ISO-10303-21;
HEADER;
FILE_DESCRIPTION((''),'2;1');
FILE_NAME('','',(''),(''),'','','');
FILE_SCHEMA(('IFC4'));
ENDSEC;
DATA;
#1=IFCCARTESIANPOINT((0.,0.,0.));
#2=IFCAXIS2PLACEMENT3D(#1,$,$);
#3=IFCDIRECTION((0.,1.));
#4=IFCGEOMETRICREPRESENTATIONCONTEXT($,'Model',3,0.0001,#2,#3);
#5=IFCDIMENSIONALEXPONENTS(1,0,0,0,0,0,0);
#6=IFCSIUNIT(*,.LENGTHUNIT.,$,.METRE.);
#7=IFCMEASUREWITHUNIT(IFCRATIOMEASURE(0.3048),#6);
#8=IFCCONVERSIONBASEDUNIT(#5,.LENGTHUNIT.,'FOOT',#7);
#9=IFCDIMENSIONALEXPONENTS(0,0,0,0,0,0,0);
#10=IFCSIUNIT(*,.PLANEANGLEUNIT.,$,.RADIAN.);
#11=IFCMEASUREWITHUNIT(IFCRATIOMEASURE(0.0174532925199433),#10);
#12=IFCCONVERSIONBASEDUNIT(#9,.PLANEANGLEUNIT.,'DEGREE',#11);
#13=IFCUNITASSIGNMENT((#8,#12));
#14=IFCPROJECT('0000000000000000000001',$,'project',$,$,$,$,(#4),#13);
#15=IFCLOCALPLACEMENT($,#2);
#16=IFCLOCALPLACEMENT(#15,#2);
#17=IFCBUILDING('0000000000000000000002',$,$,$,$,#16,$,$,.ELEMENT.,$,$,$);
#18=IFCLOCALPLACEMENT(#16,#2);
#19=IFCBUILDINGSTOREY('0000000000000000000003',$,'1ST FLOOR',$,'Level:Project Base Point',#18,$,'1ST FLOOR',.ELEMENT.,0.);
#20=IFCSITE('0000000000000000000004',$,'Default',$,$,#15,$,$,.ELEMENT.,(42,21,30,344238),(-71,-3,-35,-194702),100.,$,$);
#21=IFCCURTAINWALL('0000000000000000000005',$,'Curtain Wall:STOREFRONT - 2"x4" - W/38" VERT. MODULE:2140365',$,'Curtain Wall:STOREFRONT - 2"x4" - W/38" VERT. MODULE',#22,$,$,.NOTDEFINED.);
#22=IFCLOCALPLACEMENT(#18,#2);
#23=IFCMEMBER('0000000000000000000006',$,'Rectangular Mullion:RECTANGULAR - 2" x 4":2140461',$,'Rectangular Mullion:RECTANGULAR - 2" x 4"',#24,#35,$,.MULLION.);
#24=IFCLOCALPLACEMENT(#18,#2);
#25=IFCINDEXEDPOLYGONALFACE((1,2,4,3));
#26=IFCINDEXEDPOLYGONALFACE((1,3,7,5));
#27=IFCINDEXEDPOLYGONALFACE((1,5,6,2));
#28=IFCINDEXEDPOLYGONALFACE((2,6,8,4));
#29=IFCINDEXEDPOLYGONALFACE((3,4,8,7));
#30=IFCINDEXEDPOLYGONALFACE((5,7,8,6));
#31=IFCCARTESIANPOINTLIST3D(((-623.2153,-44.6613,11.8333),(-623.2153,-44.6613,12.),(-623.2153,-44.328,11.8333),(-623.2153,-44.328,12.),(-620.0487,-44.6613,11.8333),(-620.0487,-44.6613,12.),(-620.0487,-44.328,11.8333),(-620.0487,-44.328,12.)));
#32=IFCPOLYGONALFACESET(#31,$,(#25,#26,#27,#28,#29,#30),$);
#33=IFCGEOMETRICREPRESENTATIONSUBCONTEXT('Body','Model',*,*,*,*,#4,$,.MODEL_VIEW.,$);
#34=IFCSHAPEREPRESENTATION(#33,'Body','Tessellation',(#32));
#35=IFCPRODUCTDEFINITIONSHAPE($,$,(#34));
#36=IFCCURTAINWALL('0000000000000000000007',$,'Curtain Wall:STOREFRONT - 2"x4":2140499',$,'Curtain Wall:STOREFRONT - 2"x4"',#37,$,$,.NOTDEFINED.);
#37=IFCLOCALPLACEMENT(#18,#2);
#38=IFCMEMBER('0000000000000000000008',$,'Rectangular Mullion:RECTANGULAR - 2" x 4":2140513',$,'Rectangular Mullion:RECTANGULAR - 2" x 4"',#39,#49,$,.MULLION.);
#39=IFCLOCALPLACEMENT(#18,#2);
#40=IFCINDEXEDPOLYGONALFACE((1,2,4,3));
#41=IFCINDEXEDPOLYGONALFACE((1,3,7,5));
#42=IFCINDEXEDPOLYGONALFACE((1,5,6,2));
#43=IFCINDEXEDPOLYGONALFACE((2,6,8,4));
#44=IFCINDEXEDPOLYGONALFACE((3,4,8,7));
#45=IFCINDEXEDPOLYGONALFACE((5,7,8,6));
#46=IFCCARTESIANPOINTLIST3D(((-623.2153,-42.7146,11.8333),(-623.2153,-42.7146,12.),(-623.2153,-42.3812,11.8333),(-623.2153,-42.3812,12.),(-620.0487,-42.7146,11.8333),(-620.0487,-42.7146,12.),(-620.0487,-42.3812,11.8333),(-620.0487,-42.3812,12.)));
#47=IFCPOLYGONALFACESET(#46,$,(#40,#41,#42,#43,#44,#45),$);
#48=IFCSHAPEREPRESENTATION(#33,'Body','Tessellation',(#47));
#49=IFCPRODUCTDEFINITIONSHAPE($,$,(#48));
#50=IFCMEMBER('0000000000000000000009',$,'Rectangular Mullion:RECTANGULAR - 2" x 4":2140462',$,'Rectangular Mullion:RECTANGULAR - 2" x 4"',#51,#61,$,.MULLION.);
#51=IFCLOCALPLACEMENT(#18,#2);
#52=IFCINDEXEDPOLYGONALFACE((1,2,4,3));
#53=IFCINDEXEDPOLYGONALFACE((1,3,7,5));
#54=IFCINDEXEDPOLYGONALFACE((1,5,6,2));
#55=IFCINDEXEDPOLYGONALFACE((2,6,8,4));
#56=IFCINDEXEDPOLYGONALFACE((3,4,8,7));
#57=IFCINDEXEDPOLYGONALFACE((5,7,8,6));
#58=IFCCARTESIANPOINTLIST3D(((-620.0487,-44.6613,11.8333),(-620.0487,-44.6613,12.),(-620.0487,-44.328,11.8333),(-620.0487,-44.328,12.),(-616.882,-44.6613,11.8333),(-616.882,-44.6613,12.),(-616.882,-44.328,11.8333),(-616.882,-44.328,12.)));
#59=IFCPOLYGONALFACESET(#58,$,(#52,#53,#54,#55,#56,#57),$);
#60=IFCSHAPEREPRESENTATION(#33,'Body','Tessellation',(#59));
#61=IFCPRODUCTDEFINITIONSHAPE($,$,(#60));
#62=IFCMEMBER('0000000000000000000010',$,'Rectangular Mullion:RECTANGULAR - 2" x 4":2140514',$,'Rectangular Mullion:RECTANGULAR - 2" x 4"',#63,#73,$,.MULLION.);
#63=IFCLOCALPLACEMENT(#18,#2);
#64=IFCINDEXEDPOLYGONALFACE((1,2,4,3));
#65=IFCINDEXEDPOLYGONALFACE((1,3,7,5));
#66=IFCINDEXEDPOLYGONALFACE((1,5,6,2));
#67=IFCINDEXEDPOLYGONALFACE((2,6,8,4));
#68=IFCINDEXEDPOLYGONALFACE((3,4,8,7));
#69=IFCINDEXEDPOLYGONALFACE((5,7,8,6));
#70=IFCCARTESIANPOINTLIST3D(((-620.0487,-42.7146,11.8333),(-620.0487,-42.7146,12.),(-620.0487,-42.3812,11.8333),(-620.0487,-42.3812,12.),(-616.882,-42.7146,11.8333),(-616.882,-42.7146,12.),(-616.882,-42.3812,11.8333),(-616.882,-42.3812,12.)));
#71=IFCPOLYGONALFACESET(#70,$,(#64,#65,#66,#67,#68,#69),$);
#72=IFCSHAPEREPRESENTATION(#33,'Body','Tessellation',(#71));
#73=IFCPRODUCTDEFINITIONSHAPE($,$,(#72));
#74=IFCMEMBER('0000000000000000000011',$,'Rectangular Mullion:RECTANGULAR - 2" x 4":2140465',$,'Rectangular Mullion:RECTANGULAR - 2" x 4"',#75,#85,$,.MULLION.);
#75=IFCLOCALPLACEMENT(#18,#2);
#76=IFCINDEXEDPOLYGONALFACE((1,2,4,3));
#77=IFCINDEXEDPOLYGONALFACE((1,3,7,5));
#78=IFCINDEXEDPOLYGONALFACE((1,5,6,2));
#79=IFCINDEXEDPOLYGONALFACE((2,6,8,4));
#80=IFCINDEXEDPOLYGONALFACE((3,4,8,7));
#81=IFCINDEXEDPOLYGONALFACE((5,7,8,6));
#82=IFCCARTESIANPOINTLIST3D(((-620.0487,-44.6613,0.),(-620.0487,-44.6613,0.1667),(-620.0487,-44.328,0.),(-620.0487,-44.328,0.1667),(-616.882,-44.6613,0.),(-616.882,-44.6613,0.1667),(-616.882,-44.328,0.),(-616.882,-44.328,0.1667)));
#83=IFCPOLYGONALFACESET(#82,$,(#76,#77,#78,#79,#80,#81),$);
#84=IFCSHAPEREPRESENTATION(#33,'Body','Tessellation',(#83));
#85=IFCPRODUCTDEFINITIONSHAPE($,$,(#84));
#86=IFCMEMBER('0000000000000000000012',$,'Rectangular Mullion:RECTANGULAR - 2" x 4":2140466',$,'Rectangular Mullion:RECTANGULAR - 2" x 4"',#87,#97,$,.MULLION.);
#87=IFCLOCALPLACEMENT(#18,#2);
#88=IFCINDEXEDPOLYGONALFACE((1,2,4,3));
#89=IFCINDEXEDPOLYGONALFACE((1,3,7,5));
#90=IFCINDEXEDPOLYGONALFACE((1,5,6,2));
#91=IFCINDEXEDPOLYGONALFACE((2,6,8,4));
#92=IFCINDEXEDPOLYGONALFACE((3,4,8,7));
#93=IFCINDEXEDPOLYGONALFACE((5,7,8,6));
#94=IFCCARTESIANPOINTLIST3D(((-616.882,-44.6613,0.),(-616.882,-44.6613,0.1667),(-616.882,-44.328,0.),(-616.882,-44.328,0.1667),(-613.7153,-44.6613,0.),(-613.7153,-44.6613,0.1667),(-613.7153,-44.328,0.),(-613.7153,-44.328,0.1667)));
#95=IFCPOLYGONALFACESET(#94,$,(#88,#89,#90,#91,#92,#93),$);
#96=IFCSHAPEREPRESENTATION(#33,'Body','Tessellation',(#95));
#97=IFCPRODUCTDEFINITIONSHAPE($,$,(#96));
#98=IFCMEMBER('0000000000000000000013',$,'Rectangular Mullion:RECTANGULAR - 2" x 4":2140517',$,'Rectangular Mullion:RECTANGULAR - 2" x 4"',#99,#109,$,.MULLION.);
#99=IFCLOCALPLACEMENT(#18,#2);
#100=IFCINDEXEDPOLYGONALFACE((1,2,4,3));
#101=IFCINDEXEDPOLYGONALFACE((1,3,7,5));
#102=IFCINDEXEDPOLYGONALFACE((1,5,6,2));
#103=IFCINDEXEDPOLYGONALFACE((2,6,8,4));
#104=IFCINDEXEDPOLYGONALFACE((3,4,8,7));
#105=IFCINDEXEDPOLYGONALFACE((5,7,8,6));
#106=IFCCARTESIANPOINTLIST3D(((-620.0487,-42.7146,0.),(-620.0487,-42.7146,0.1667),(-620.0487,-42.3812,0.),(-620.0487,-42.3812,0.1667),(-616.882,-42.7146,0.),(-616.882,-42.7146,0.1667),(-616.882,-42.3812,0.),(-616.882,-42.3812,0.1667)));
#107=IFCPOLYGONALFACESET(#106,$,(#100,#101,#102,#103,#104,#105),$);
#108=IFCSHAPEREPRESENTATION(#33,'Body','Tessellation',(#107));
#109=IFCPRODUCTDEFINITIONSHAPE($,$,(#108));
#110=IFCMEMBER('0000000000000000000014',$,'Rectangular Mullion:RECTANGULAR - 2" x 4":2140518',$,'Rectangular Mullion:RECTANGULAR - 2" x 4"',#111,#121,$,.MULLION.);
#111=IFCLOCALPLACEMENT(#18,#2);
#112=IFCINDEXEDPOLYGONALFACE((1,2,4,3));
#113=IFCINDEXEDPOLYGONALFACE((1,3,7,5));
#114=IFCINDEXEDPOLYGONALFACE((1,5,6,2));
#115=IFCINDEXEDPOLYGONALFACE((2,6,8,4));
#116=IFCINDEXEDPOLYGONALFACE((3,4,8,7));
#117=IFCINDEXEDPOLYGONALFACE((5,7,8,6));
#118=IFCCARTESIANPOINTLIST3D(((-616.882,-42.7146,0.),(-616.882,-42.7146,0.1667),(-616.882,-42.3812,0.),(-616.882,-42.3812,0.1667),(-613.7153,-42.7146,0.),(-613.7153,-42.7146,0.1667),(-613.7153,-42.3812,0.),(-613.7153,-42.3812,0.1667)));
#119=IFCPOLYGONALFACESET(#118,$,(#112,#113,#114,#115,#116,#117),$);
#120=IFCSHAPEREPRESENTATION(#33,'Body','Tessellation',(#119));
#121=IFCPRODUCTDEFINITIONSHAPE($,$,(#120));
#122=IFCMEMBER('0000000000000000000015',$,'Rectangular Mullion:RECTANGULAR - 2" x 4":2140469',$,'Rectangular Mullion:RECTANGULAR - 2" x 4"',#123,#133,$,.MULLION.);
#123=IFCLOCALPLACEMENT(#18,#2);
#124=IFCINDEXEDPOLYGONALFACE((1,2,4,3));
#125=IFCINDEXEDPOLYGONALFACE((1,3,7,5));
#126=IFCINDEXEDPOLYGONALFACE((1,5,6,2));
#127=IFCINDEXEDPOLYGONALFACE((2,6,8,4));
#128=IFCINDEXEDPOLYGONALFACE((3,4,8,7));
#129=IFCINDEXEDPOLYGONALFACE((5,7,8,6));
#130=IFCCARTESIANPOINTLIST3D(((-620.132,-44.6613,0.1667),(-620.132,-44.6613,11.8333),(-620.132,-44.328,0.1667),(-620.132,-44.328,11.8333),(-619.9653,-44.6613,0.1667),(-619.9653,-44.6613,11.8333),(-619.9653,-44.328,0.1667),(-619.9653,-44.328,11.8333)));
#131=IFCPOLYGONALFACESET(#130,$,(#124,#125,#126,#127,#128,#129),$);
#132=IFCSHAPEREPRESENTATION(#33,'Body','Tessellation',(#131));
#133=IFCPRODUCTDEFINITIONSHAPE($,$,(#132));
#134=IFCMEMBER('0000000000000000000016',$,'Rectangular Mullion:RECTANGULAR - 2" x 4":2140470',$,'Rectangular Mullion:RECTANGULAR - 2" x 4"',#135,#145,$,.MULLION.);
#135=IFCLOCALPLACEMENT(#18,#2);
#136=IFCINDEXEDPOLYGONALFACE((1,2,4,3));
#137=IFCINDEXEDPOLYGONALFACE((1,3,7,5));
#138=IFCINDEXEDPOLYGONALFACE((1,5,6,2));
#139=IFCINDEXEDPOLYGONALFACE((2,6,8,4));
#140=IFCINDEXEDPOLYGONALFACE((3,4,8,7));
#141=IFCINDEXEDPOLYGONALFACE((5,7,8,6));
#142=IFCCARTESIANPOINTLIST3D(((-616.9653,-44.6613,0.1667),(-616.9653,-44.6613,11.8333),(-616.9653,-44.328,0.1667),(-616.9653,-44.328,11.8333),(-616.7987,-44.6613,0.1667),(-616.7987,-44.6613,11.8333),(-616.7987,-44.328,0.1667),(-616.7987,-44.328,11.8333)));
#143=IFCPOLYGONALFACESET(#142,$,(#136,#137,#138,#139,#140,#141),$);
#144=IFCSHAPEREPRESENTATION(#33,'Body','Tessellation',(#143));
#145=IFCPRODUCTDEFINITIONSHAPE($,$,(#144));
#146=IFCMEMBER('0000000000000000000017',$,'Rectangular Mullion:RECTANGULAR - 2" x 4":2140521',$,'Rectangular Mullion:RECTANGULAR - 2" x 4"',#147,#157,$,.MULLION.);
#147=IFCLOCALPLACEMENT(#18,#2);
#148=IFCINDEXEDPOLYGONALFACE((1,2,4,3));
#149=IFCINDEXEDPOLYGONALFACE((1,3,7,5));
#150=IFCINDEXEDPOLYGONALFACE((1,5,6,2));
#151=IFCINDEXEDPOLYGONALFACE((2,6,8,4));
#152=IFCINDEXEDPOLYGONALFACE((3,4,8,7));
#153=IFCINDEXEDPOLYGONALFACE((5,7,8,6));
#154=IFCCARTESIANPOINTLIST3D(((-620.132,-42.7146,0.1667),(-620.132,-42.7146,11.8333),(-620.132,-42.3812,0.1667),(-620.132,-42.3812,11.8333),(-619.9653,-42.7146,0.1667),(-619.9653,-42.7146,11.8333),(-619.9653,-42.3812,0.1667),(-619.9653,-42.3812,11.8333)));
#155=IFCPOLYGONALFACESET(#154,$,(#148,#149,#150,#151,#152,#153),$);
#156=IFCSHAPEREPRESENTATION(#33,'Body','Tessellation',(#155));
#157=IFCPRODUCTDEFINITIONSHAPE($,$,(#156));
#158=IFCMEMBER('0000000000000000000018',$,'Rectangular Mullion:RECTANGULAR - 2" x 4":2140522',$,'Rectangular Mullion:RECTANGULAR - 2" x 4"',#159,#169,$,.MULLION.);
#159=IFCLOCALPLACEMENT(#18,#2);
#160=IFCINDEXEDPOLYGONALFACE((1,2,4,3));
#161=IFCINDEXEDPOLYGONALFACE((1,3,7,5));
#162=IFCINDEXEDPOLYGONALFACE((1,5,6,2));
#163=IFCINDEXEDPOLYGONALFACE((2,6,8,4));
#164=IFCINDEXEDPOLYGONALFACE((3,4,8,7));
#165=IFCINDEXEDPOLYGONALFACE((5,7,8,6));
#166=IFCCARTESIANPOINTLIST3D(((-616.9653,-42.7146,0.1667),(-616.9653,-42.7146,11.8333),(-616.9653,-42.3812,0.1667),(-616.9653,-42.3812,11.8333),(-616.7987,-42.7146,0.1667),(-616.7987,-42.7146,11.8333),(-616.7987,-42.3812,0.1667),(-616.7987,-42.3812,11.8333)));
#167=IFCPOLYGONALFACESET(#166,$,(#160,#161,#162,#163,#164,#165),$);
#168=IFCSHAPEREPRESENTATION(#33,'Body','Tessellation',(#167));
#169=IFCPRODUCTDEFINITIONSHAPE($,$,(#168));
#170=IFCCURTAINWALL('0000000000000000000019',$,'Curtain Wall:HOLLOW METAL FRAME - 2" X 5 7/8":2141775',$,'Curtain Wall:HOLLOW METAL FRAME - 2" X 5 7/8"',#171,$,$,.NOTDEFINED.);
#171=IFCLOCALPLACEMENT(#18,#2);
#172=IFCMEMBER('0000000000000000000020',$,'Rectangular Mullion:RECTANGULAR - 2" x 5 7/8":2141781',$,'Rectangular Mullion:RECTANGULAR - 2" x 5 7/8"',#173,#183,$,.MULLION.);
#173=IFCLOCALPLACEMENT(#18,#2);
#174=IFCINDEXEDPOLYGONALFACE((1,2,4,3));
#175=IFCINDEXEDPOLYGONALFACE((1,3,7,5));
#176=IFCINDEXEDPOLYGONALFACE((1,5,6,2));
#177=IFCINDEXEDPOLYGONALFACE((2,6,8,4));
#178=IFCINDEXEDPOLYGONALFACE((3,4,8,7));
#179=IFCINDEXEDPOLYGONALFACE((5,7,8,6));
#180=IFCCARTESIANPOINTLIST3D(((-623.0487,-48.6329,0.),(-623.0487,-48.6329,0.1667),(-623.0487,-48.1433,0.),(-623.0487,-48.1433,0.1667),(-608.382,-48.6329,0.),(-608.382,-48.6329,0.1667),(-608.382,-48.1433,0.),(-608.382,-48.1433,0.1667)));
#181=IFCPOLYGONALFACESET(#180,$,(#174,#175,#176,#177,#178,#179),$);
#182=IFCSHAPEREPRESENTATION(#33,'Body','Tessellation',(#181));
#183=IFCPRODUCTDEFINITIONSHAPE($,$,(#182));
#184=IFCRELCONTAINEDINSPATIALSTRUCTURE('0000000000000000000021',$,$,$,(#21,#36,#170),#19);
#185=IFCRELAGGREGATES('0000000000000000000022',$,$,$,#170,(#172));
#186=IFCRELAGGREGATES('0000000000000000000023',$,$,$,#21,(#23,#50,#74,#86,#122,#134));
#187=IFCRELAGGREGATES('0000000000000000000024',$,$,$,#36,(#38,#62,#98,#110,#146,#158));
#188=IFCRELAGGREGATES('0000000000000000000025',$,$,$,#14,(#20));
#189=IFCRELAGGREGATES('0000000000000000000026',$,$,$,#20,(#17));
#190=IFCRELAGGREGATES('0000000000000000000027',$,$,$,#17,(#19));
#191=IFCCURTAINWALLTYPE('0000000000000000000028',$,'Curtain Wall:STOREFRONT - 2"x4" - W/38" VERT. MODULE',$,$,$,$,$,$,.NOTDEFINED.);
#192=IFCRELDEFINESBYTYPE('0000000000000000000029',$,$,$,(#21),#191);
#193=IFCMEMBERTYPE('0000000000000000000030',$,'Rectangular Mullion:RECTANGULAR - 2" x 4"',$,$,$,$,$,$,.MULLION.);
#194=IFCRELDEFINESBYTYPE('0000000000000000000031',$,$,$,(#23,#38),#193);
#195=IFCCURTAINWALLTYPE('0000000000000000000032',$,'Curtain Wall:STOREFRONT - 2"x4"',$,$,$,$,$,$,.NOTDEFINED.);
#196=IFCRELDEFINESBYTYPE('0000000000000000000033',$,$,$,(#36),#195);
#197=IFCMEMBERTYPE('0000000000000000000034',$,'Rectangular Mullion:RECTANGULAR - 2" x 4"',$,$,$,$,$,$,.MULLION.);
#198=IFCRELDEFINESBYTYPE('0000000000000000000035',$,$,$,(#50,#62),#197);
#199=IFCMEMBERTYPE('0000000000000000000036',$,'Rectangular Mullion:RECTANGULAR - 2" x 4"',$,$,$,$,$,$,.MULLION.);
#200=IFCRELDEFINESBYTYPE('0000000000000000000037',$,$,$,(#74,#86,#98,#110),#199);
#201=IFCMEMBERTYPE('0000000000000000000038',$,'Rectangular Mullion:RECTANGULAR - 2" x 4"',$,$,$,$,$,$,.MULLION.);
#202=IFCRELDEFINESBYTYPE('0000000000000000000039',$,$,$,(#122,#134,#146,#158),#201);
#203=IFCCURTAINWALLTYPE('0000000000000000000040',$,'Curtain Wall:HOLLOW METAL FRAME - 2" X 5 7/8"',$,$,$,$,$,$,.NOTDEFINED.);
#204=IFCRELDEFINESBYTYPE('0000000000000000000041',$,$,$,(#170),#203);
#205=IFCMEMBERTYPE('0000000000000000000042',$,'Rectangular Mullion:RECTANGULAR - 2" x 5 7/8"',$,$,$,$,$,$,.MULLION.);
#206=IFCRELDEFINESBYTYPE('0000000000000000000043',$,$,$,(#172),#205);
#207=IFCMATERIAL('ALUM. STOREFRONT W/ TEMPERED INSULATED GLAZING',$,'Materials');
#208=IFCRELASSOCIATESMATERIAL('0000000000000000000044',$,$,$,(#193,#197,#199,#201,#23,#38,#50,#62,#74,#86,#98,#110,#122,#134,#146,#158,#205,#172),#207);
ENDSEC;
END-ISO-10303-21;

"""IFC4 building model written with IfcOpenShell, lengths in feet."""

from ifc_helpers import new_model, entity, si_unit, converted_unit, direction, frame, origin, origin_2d_with_axis, place, context, subcontext, project, spatial, rectangle, extrude, source, transform, mapped, material, material_profile, profile_set, profile_usage, type_object, type_shapes, element, aggregate, save


model = new_model("IFC4")

# Units and contexts
model_context = context("Model", 3, precision=0.0001, world=origin(), true_north=direction((0.0, 1.0)))
body_context = subcontext(model_context, "Body", "Model", "MODEL_VIEW")
ifc_project = project(units=[converted_unit("LENGTHUNIT", "FOOT", entity("IfcRatioMeasure", 0.3048), si_unit("LENGTHUNIT", "METRE"), dimensions=[1, 0, 0, 0, 0, 0, 0]), converted_unit("PLANEANGLEUNIT", "DEGREE", entity("IfcRatioMeasure", 0.0174532925199433), si_unit("PLANEANGLEUNIT", "RADIAN"), dimensions=[0, 0, 0, 0, 0, 0, 0])], contexts=[model_context])

# Site, building, storey
site_placement = place(None, origin())
site = spatial("IfcSite", under=ifc_project, at=site_placement, Name="Default", CompositionType="ELEMENT", RefLatitude=(42, 21, 30, 344238), RefLongitude=(-71, -3, -35, -194702), RefElevation=100.0)
building_placement = place(site_placement, origin())
building = spatial("IfcBuilding", under=site, at=building_placement, CompositionType="ELEMENT")
storey_placement = place(building_placement, origin())
storey = spatial("IfcBuildingStorey", under=building, at=storey_placement, Name="1ST FLOOR", ObjectType="Level:Project Base Point", LongName="1ST FLOOR", CompositionType="ELEMENT", Elevation=0.0)

# Curtain walls, members
curtain_wall_type_1 = type_object("IfcCurtainWallType", Name="Curtain Wall:STOREFRONT - 2\"x4\" - W/38\" VERT. MODULE", PredefinedType="NOTDEFINED")
curtain_wall_1_placement = place(storey_placement, origin())
curtain_wall_1 = element("IfcCurtainWall", 1, at=curtain_wall_1_placement, inside=storey, type_object=curtain_wall_type_1, Name="Curtain Wall:STOREFRONT - 2\"x4\" - W/38\" VERT. MODULE:2140365", ObjectType="Curtain Wall:STOREFRONT - 2\"x4\" - W/38\" VERT. MODULE", PredefinedType="NOTDEFINED")
ifc_material_1 = material(Name="ALUM. STOREFRONT W/ TEMPERED INSULATED GLAZING", Category="Materials")
ifc_material_profile_1 = material_profile(ifc_material_1, rectangle(XDim=0.3333, YDim=0.1667, at=origin_2d_with_axis()), Name="RECTANGULAR - 2\" x 4\"")
ifc_profile_set_1 = profile_set([ifc_material_profile_1], Name="RECTANGULAR - 2\" x 4\"")
ifc_profile_usage_1 = profile_usage(ifc_profile_set_1)
member_type_1 = type_object("IfcMemberType", Name="Rectangular Mullion:RECTANGULAR - 2\" x 4\"", PredefinedType="MULLION", material=ifc_profile_set_1)
shared_shape_1 = source(origin(), body_context, "Body", "SweptSolid", [
    extrude(rectangle(XDim=0.3333, YDim=0.1667, at=origin_2d_with_axis()), frame((-0.0833, 0.0, -3.1667), z_axis=(0.0, 0.0, 1.0), x_axis=(0.0, -1.0, 0.0)), (0.0, 0.0, 1.0), 3.1667),
])
type_shapes(member_type_1, [shared_shape_1])
member_1_placement = place(storey_placement, frame((-620.0487, -44.4946, 12.0), z_axis=(1.0, 0.0, 0.0), x_axis=(0.0, 0.0, 1.0)))
member_1 = element("IfcMember", 2, at=member_1_placement, type_object=member_type_1, material=ifc_profile_usage_1, Name="Rectangular Mullion:RECTANGULAR - 2\" x 4\":2140461", ObjectType="Rectangular Mullion:RECTANGULAR - 2\" x 4\"", PredefinedType="MULLION", context=body_context, shape_type="MappedRepresentation", body=[
    mapped(shared_shape_1, transform((0.0, 0.0, 0.0), scale=1.0)),
])
curtain_wall_type_2 = type_object("IfcCurtainWallType", Name="Curtain Wall:STOREFRONT - 2\"x4\"", PredefinedType="NOTDEFINED")
curtain_wall_2_placement = place(storey_placement, origin())
curtain_wall_2 = element("IfcCurtainWall", 3, at=curtain_wall_2_placement, inside=storey, type_object=curtain_wall_type_2, Name="Curtain Wall:STOREFRONT - 2\"x4\":2140499", ObjectType="Curtain Wall:STOREFRONT - 2\"x4\"", PredefinedType="NOTDEFINED")
ifc_profile_usage_2 = profile_usage(ifc_profile_set_1)
member_2_placement = place(storey_placement, frame((-620.0487, -42.5479, 12.0), z_axis=(1.0, 0.0, 0.0), x_axis=(0.0, 0.0, 1.0)))
member_2 = element("IfcMember", 4, at=member_2_placement, type_object=member_type_1, material=ifc_profile_usage_2, Name="Rectangular Mullion:RECTANGULAR - 2\" x 4\":2140513", ObjectType="Rectangular Mullion:RECTANGULAR - 2\" x 4\"", PredefinedType="MULLION", context=body_context, shape_type="MappedRepresentation", body=[
    mapped(shared_shape_1, transform((0.0, 0.0, 0.0), scale=1.0)),
])

# Members
ifc_profile_usage_3 = profile_usage(ifc_profile_set_1)
member_type_2 = type_object("IfcMemberType", Name="Rectangular Mullion:RECTANGULAR - 2\" x 4\"", PredefinedType="MULLION", material=ifc_profile_set_1)
shared_shape_2 = source(origin(), body_context, "Body", "SweptSolid", [
    extrude(rectangle(XDim=0.3333, YDim=0.1667, at=origin_2d_with_axis()), frame((-0.0833, 0.0, -3.1667), z_axis=(0.0, 0.0, 1.0), x_axis=(0.0, -1.0, 0.0)), (0.0, 0.0, 1.0), 3.1667),
])
type_shapes(member_type_2, [shared_shape_2])
member_3_placement = place(storey_placement, frame((-616.882, -44.4946, 12.0), z_axis=(1.0, 0.0, 0.0), x_axis=(0.0, 0.0, 1.0)))
member_3 = element("IfcMember", 5, at=member_3_placement, type_object=member_type_2, material=ifc_profile_usage_3, Name="Rectangular Mullion:RECTANGULAR - 2\" x 4\":2140462", ObjectType="Rectangular Mullion:RECTANGULAR - 2\" x 4\"", PredefinedType="MULLION", context=body_context, shape_type="MappedRepresentation", body=[
    mapped(shared_shape_2, transform((0.0, 0.0, 0.0), scale=1.0)),
])
ifc_profile_usage_4 = profile_usage(ifc_profile_set_1)
member_4_placement = place(storey_placement, frame((-616.882, -42.5479, 12.0), z_axis=(1.0, 0.0, 0.0), x_axis=(0.0, 0.0, 1.0)))
member_4 = element("IfcMember", 6, at=member_4_placement, type_object=member_type_2, material=ifc_profile_usage_4, Name="Rectangular Mullion:RECTANGULAR - 2\" x 4\":2140514", ObjectType="Rectangular Mullion:RECTANGULAR - 2\" x 4\"", PredefinedType="MULLION", context=body_context, shape_type="MappedRepresentation", body=[
    mapped(shared_shape_2, transform((0.0, 0.0, 0.0), scale=1.0)),
])
ifc_profile_usage_5 = profile_usage(ifc_profile_set_1)
member_type_3 = type_object("IfcMemberType", Name="Rectangular Mullion:RECTANGULAR - 2\" x 4\"", PredefinedType="MULLION", material=ifc_profile_set_1)
shared_shape_3 = source(origin(), body_context, "Body", "SweptSolid", [
    extrude(rectangle(XDim=0.3333, YDim=0.1667, at=origin_2d_with_axis()), frame((-0.0833, 0.0, -3.1667), z_axis=(0.0, 0.0, 1.0), x_axis=(0.0, -1.0, 0.0)), (0.0, 0.0, 1.0), 3.1667),
])
type_shapes(member_type_3, [shared_shape_3])
member_5_placement = place(storey_placement, frame((-620.0487, -44.4946, 0.0), z_axis=(-1.0, 0.0, 0.0), x_axis=(0.0, 0.0, -1.0)))
member_5 = element("IfcMember", 7, at=member_5_placement, type_object=member_type_3, material=ifc_profile_usage_5, Name="Rectangular Mullion:RECTANGULAR - 2\" x 4\":2140465", ObjectType="Rectangular Mullion:RECTANGULAR - 2\" x 4\"", PredefinedType="MULLION", context=body_context, shape_type="MappedRepresentation", body=[
    mapped(shared_shape_3, transform((0.0, 0.0, 0.0), scale=1.0)),
])
ifc_profile_usage_6 = profile_usage(ifc_profile_set_1)
member_6_placement = place(storey_placement, frame((-616.882, -44.4946, 0.0), z_axis=(-1.0, 0.0, 0.0), x_axis=(0.0, 0.0, -1.0)))
member_6 = element("IfcMember", 8, at=member_6_placement, type_object=member_type_3, material=ifc_profile_usage_6, Name="Rectangular Mullion:RECTANGULAR - 2\" x 4\":2140466", ObjectType="Rectangular Mullion:RECTANGULAR - 2\" x 4\"", PredefinedType="MULLION", context=body_context, shape_type="MappedRepresentation", body=[
    mapped(shared_shape_3, transform((0.0, 0.0, 0.0), scale=1.0)),
])
ifc_profile_usage_7 = profile_usage(ifc_profile_set_1)
member_7_placement = place(storey_placement, frame((-620.0487, -42.5479, 0.0), z_axis=(-1.0, 0.0, 0.0), x_axis=(0.0, 0.0, -1.0)))
member_7 = element("IfcMember", 9, at=member_7_placement, type_object=member_type_3, material=ifc_profile_usage_7, Name="Rectangular Mullion:RECTANGULAR - 2\" x 4\":2140517", ObjectType="Rectangular Mullion:RECTANGULAR - 2\" x 4\"", PredefinedType="MULLION", context=body_context, shape_type="MappedRepresentation", body=[
    mapped(shared_shape_3, transform((0.0, 0.0, 0.0), scale=1.0)),
])
ifc_profile_usage_8 = profile_usage(ifc_profile_set_1)
member_8_placement = place(storey_placement, frame((-616.882, -42.5479, 0.0), z_axis=(-1.0, 0.0, 0.0), x_axis=(0.0, 0.0, -1.0)))
member_8 = element("IfcMember", 10, at=member_8_placement, type_object=member_type_3, material=ifc_profile_usage_8, Name="Rectangular Mullion:RECTANGULAR - 2\" x 4\":2140518", ObjectType="Rectangular Mullion:RECTANGULAR - 2\" x 4\"", PredefinedType="MULLION", context=body_context, shape_type="MappedRepresentation", body=[
    mapped(shared_shape_3, transform((0.0, 0.0, 0.0), scale=1.0)),
])
ifc_profile_usage_9 = profile_usage(ifc_profile_set_1)
member_type_4 = type_object("IfcMemberType", Name="Rectangular Mullion:RECTANGULAR - 2\" x 4\"", PredefinedType="MULLION", material=ifc_profile_set_1)
shared_shape_4 = source(origin(), body_context, "Body", "SweptSolid", [
    extrude(rectangle(XDim=0.3333, YDim=0.1667, at=origin_2d_with_axis()), frame((0.0, 0.0, -11.6667), z_axis=(0.0, 0.0, 1.0), x_axis=(0.0, -1.0, 0.0)), (0.0, 0.0, 1.0), 11.6667),
])
type_shapes(member_type_4, [shared_shape_4])
member_9_placement = place(storey_placement, frame((-620.0487, -44.4946, 0.1667), z_axis=(0.0, 0.0, -1.0), x_axis=(1.0, 0.0, 0.0)))
member_9 = element("IfcMember", 11, at=member_9_placement, type_object=member_type_4, material=ifc_profile_usage_9, Name="Rectangular Mullion:RECTANGULAR - 2\" x 4\":2140469", ObjectType="Rectangular Mullion:RECTANGULAR - 2\" x 4\"", PredefinedType="MULLION", context=body_context, shape_type="MappedRepresentation", body=[
    mapped(shared_shape_4, transform((0.0, 0.0, 0.0), scale=1.0)),
])
ifc_profile_usage_10 = profile_usage(ifc_profile_set_1)
member_10_placement = place(storey_placement, frame((-616.882, -44.4946, 0.1667), z_axis=(0.0, 0.0, -1.0), x_axis=(1.0, 0.0, 0.0)))
member_10 = element("IfcMember", 12, at=member_10_placement, type_object=member_type_4, material=ifc_profile_usage_10, Name="Rectangular Mullion:RECTANGULAR - 2\" x 4\":2140470", ObjectType="Rectangular Mullion:RECTANGULAR - 2\" x 4\"", PredefinedType="MULLION", context=body_context, shape_type="MappedRepresentation", body=[
    mapped(shared_shape_4, transform((0.0, 0.0, 0.0), scale=1.0)),
])
ifc_profile_usage_11 = profile_usage(ifc_profile_set_1)
member_11_placement = place(storey_placement, frame((-620.0487, -42.5479, 0.1667), z_axis=(0.0, 0.0, -1.0), x_axis=(1.0, 0.0, 0.0)))
member_11 = element("IfcMember", 13, at=member_11_placement, type_object=member_type_4, material=ifc_profile_usage_11, Name="Rectangular Mullion:RECTANGULAR - 2\" x 4\":2140521", ObjectType="Rectangular Mullion:RECTANGULAR - 2\" x 4\"", PredefinedType="MULLION", context=body_context, shape_type="MappedRepresentation", body=[
    mapped(shared_shape_4, transform((0.0, 0.0, 0.0), scale=1.0)),
])
ifc_profile_usage_12 = profile_usage(ifc_profile_set_1)
member_12_placement = place(storey_placement, frame((-616.882, -42.5479, 0.1667), z_axis=(0.0, 0.0, -1.0), x_axis=(1.0, 0.0, 0.0)))
member_12 = element("IfcMember", 14, at=member_12_placement, type_object=member_type_4, material=ifc_profile_usage_12, Name="Rectangular Mullion:RECTANGULAR - 2\" x 4\":2140522", ObjectType="Rectangular Mullion:RECTANGULAR - 2\" x 4\"", PredefinedType="MULLION", context=body_context, shape_type="MappedRepresentation", body=[
    mapped(shared_shape_4, transform((0.0, 0.0, 0.0), scale=1.0)),
])

# Curtain wall, member
curtain_wall_type_3 = type_object("IfcCurtainWallType", Name="Curtain Wall:HOLLOW METAL FRAME - 2\" X 5 7/8\"", PredefinedType="NOTDEFINED")
curtain_wall_3_placement = place(storey_placement, origin())
curtain_wall_3 = element("IfcCurtainWall", 15, at=curtain_wall_3_placement, inside=storey, type_object=curtain_wall_type_3, Name="Curtain Wall:HOLLOW METAL FRAME - 2\" X 5 7/8\":2141775", ObjectType="Curtain Wall:HOLLOW METAL FRAME - 2\" X 5 7/8\"", PredefinedType="NOTDEFINED")
ifc_material_profile_2 = material_profile(ifc_material_1, rectangle(XDim=0.4896, YDim=0.1667, at=origin_2d_with_axis()), Name="RECTANGULAR - 2\" x 5 7/8\"")
ifc_profile_set_2 = profile_set([ifc_material_profile_2], Name="RECTANGULAR - 2\" x 5 7/8\"")
ifc_profile_usage_13 = profile_usage(ifc_profile_set_2)
member_type_5 = type_object("IfcMemberType", Name="Rectangular Mullion:RECTANGULAR - 2\" x 5 7/8\"", PredefinedType="MULLION", material=ifc_profile_set_2)
shared_shape_5 = source(origin(), body_context, "Body", "SweptSolid", [
    extrude(rectangle(XDim=0.4896, YDim=0.1667, at=origin_2d_with_axis()), frame((-0.0833, 0.0, -14.6667), z_axis=(0.0, 0.0, 1.0), x_axis=(0.0, -1.0, 0.0)), (0.0, 0.0, 1.0), 14.6667),
])
type_shapes(member_type_5, [shared_shape_5])
member_13_placement = place(storey_placement, frame((-623.0487, -48.3881, 0.0), z_axis=(-1.0, 0.0, 0.0), x_axis=(0.0, 0.0, -1.0)))
member_13 = element("IfcMember", 16, at=member_13_placement, type_object=member_type_5, material=ifc_profile_usage_13, Name="Rectangular Mullion:RECTANGULAR - 2\" x 5 7/8\":2141781", ObjectType="Rectangular Mullion:RECTANGULAR - 2\" x 5 7/8\"", PredefinedType="MULLION", context=body_context, shape_type="MappedRepresentation", body=[
    mapped(shared_shape_5, transform((0.0, 0.0, 0.0), scale=1.0)),
])
aggregate(curtain_wall_3, [member_13])

aggregate(curtain_wall_1, [member_1, member_3, member_5, member_6, member_9, member_10])
aggregate(curtain_wall_2, [member_2, member_4, member_7, member_8, member_11, member_12])

save(model, "model.ifc")
